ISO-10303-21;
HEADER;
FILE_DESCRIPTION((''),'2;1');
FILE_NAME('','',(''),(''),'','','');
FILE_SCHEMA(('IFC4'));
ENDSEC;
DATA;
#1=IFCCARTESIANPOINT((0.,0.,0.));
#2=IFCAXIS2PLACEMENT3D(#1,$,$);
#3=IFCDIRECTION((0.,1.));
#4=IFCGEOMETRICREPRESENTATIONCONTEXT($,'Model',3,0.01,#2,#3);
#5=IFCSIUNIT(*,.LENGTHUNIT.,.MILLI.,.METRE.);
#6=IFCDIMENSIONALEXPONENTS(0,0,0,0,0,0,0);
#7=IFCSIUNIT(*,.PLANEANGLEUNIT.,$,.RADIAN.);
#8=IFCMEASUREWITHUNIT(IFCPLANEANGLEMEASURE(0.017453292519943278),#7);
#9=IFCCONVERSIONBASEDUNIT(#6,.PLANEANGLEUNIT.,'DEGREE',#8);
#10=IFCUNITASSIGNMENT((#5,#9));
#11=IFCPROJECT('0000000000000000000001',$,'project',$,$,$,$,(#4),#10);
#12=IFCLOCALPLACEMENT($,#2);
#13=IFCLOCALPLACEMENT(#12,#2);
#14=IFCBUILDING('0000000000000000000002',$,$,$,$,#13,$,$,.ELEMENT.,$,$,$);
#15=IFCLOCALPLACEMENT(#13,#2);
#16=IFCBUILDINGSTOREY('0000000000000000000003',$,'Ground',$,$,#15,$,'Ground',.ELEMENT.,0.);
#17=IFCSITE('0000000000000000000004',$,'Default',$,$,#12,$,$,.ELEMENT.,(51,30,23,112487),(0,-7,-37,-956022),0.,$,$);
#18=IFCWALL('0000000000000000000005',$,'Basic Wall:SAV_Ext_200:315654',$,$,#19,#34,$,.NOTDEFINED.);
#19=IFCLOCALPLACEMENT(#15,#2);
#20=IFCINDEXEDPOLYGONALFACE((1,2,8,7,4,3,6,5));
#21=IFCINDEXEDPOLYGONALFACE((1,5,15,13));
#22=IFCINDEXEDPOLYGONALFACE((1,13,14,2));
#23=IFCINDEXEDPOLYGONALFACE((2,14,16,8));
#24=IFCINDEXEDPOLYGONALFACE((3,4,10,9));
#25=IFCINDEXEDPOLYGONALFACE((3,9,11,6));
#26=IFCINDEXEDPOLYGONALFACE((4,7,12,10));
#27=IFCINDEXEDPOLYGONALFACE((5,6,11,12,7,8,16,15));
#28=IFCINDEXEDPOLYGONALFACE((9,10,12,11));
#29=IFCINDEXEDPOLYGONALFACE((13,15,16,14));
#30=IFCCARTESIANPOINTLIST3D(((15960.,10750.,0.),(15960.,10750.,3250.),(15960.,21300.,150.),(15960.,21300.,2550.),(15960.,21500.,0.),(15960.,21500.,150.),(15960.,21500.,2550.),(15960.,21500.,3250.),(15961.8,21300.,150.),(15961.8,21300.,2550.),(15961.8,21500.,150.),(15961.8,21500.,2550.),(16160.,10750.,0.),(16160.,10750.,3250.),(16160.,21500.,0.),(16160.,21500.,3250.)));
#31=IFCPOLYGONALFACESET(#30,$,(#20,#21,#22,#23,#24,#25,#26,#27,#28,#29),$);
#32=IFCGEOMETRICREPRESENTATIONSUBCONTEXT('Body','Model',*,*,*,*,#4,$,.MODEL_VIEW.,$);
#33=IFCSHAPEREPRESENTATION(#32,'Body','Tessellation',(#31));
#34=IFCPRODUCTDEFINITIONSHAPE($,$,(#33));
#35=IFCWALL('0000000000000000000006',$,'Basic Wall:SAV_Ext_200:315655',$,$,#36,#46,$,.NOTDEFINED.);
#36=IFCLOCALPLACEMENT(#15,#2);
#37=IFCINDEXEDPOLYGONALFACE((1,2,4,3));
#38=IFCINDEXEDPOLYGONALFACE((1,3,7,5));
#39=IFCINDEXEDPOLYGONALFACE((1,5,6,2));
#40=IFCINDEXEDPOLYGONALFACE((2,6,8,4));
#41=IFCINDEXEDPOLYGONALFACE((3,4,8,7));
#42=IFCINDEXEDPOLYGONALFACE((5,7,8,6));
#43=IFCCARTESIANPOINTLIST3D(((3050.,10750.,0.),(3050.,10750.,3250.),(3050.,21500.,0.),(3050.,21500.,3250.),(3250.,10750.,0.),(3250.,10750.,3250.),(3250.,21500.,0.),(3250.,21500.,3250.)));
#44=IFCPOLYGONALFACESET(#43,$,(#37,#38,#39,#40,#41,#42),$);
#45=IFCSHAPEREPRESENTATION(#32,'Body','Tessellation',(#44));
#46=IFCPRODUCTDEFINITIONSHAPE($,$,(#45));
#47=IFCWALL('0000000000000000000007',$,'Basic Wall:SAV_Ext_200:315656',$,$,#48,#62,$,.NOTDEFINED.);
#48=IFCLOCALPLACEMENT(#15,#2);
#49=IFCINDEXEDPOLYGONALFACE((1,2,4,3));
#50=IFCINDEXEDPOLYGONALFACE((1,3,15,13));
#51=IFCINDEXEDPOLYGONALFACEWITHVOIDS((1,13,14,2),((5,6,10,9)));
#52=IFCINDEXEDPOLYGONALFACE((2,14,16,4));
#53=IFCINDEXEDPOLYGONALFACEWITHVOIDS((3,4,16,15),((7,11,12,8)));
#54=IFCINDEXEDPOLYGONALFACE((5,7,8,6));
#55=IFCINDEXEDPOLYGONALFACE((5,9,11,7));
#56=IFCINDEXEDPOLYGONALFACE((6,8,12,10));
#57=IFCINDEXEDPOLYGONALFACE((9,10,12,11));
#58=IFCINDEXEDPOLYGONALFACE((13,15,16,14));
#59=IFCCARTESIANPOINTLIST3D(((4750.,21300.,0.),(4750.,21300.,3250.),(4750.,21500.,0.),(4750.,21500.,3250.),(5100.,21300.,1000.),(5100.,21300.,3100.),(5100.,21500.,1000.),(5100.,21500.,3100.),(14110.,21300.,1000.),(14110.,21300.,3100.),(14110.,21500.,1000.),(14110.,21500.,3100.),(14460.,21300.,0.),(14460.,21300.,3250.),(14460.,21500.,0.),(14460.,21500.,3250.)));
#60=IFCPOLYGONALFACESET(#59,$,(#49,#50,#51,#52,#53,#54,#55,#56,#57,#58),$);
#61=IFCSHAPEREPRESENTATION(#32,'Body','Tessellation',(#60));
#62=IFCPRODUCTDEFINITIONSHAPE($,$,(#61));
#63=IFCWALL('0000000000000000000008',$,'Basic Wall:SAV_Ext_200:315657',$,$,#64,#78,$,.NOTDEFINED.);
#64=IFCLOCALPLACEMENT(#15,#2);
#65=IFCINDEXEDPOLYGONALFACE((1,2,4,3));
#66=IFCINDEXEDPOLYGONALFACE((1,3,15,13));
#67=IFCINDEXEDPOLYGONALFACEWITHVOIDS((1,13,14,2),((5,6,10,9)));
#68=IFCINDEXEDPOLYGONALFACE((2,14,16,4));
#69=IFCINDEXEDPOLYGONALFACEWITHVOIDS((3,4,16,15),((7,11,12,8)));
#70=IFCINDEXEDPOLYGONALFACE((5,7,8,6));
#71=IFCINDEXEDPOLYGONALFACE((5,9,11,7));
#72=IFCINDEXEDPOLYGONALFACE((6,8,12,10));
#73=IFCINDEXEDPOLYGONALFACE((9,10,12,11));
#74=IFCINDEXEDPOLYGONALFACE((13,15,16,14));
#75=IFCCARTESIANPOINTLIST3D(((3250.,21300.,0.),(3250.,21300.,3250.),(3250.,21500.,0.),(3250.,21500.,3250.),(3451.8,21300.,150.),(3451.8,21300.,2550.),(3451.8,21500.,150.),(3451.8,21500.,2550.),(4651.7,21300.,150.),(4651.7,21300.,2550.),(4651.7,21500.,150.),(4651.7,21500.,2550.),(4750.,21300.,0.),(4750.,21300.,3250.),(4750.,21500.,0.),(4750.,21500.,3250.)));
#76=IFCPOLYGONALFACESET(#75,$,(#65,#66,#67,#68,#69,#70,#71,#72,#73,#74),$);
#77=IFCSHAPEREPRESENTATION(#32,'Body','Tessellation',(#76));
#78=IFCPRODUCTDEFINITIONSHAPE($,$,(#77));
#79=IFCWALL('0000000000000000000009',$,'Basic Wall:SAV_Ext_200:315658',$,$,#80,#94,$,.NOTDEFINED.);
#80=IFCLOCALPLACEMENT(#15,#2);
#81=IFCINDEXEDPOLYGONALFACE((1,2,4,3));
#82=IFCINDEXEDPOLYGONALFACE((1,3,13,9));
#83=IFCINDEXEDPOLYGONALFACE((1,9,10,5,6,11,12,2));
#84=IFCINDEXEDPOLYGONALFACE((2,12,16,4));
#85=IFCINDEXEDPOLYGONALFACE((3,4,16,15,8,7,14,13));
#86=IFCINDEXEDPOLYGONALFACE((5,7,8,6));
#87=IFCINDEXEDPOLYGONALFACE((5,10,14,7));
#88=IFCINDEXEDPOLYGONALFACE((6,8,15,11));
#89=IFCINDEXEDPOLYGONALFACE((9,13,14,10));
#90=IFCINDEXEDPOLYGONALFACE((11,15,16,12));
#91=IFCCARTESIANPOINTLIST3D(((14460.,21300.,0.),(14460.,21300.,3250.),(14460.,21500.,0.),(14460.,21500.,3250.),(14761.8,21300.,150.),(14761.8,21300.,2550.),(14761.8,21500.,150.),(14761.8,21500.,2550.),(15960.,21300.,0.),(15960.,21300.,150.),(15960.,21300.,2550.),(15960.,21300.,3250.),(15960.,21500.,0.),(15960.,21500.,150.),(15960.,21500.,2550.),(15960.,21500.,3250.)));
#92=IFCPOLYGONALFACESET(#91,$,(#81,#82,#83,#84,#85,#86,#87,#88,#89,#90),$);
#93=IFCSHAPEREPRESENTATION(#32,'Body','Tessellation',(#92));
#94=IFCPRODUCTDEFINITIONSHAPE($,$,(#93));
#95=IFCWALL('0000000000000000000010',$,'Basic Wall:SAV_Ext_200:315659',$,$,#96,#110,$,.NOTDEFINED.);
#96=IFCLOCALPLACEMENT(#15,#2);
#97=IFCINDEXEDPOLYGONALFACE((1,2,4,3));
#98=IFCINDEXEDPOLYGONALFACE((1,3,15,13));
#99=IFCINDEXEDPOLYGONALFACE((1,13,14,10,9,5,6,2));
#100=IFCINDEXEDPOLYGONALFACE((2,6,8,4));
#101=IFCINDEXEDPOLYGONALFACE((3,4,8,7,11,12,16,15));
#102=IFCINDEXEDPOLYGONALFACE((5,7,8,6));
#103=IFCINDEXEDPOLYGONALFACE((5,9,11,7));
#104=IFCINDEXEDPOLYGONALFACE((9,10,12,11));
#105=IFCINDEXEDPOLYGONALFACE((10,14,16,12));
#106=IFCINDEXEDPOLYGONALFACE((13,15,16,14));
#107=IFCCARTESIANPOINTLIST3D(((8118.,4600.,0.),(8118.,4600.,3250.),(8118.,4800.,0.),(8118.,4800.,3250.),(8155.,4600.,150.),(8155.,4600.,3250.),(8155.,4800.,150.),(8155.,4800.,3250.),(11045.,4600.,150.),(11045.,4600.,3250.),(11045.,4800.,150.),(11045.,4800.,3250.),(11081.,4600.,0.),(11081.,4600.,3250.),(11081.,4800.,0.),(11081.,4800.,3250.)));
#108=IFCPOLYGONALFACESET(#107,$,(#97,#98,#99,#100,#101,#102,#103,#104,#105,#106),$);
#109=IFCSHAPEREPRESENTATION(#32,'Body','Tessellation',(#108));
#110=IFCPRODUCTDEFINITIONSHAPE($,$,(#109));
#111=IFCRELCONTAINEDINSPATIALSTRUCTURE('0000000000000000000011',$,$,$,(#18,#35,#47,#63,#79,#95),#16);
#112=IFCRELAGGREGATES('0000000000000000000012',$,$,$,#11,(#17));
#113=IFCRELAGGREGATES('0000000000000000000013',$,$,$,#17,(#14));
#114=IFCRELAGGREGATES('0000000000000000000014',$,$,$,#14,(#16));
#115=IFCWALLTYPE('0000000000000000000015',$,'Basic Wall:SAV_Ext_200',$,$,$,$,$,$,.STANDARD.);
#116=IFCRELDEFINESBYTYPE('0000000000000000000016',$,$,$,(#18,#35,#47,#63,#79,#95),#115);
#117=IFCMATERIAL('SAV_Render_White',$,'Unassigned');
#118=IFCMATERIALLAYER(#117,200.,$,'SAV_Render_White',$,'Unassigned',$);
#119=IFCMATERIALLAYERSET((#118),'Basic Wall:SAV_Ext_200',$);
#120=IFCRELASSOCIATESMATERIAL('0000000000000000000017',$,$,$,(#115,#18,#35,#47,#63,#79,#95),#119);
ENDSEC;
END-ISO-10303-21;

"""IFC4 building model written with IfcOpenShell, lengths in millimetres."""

from ifc_helpers import new_model, entity, si_unit, converted_unit, direction, frame, frame_2d, origin, place, context, subcontext, project, spatial, rectangle, extrude, material, layer, layer_set, layer_usage, type_object, element, save


model = new_model("IFC4")

# Units and contexts
model_context = context("Model", 3, precision=0.01, world=origin(), true_north=direction((0.0, 1.0)))
body_context = subcontext(model_context, "Body", "Model", "MODEL_VIEW")
ifc_project = project(units=[si_unit("LENGTHUNIT", "METRE", prefix="MILLI"), converted_unit("PLANEANGLEUNIT", "DEGREE", entity("IfcPlaneAngleMeasure", 0.017453292519943278), si_unit("PLANEANGLEUNIT", "RADIAN"), dimensions=[0, 0, 0, 0, 0, 0, 0])], contexts=[model_context])

# Site, building, storey
site_placement = place(None, origin())
site = spatial("IfcSite", under=ifc_project, at=site_placement, Name="Default", CompositionType="ELEMENT", RefLatitude=(51, 30, 23, 112487), RefLongitude=(0, -7, -37, -956022), RefElevation=0.0)
building_placement = place(site_placement, origin())
building = spatial("IfcBuilding", under=site, at=building_placement, CompositionType="ELEMENT")
storey_placement = place(building_placement, origin())
storey = spatial("IfcBuildingStorey", under=building, at=storey_placement, Name="Ground", LongName="Ground", CompositionType="ELEMENT", Elevation=0.0)

# Shared definitions
ifc_material = material(Name="SAV_Render_White", Category="Unassigned")
ifc_layer = layer(ifc_material, 200.0, Name="SAV_Render_White", Category="Unassigned")
ifc_layer_set = layer_set([ifc_layer], Name="Basic Wall:SAV_Ext_200")
wall_type = type_object("IfcWallType", Name="Basic Wall:SAV_Ext_200", PredefinedType="STANDARD", material=ifc_layer_set)

# Wall, opening
ifc_layer_usage_1 = layer_usage(ifc_layer_set, "AXIS2", "NEGATIVE", 100.0)
wall_1_placement = place(storey_placement, frame((16060.0, 10750.0, 0.0), z_axis=(0.0, 0.0, 1.0), x_axis=(0.0, 1.0, 0.0)))
wall_1 = element("IfcWall", 1, at=wall_1_placement, inside=storey, type_object=wall_type, material=ifc_layer_usage_1, Name="Basic Wall:SAV_Ext_200:315654", PredefinedType="NOTDEFINED", context=body_context, shape_type="SweptSolid", body=[
    extrude(rectangle(XDim=10750.0, YDim=200.0, at=frame_2d((5375.0, 0.0), x_axis=(-1.0, 0.0))), origin(), (0.0, 0.0, 1.0), 3250.0),
])
opening_1_placement = place(wall_1_placement, frame((-10750.0, 16060.0, 150.0)))
element("IfcOpeningElement", 2, at=opening_1_placement, cuts=wall_1, PredefinedType="OPENING", context=body_context, shape_type="SweptSolid", body=[
    extrude(rectangle(XDim=2400.0, YDim=200.0, at=frame_2d((0.0, 0.0), x_axis=(0.0, 1.0))), frame((21400.0, -15961.8, 1200.0), z_axis=(0.0, 1.0, 0.0), x_axis=(1.0, 0.0, 0.0)), (0.0, 0.0, 1.0), 1200.0),
])

# Wall
ifc_layer_usage_2 = layer_usage(ifc_layer_set, "AXIS2", "NEGATIVE", 100.0)
wall_2_placement = place(storey_placement, frame((3150.0, 21500.0, 0.0), z_axis=(0.0, 0.0, 1.0), x_axis=(0.0, -1.0, 0.0)))
element("IfcWall", 3, at=wall_2_placement, inside=storey, type_object=wall_type, material=ifc_layer_usage_2, Name="Basic Wall:SAV_Ext_200:315655", PredefinedType="NOTDEFINED", context=body_context, shape_type="SweptSolid", body=[
    extrude(rectangle(XDim=10750.0, YDim=200.0, at=frame_2d((5375.0, 0.0), x_axis=(-1.0, 0.0))), origin(), (0.0, 0.0, 1.0), 3250.0),
])

# Walls, openings
ifc_layer_usage_3 = layer_usage(ifc_layer_set, "AXIS2", "NEGATIVE", 100.0)
wall_3_placement = place(storey_placement, frame((4750.0, 21400.0, 0.0)))
wall_3 = element("IfcWall", 4, at=wall_3_placement, inside=storey, type_object=wall_type, material=ifc_layer_usage_3, Name="Basic Wall:SAV_Ext_200:315656", PredefinedType="NOTDEFINED", context=body_context, shape_type="SweptSolid", body=[
    extrude(rectangle(XDim=9710.0, YDim=200.0, at=frame_2d((4855.0, 0.0), x_axis=(-1.0, 0.0))), origin(), (0.0, 0.0, 1.0), 3250.0),
])
opening_2_placement = place(wall_3_placement, frame((350.0, -100.0, 1000.0)))
element("IfcOpeningElement", 5, at=opening_2_placement, cuts=wall_3, PredefinedType="OPENING", context=body_context, shape_type="SweptSolid", body=[
    extrude(rectangle(XDim=2100.0, YDim=9010.0, at=frame_2d((1050.0, 4505.0), x_axis=(-1.0, 0.0))), frame((0.0, 0.0, 0.0), z_axis=(0.0, 1.0, 0.0), x_axis=(0.0, 0.0, 1.0)), (0.0, 0.0, 1.0), 200.0),
])
ifc_layer_usage_4 = layer_usage(ifc_layer_set, "AXIS2", "NEGATIVE", 100.0)
wall_4_placement = place(storey_placement, frame((3250.0, 21400.0, 0.0)))
wall_4 = element("IfcWall", 6, at=wall_4_placement, inside=storey, type_object=wall_type, material=ifc_layer_usage_4, Name="Basic Wall:SAV_Ext_200:315657", PredefinedType="NOTDEFINED", context=body_context, shape_type="SweptSolid", body=[
    extrude(rectangle(XDim=1500.0, YDim=200.0, at=frame_2d((750.0, 0.0), x_axis=(-1.0, 0.0))), origin(), (0.0, 0.0, 1.0), 3250.0),
])
opening_3_placement = place(wall_4_placement, frame((1401.7, 100.0, 150.0)))
element("IfcOpeningElement", 7, at=opening_3_placement, cuts=wall_4, PredefinedType="OPENING", context=body_context, shape_type="SweptSolid", body=[
    extrude(rectangle(XDim=2400.0, YDim=1200.0, at=frame_2d((1200.0, 600.0), x_axis=(-1.0, 0.0))), frame((0.0, 0.0, 0.0), z_axis=(0.0, -1.0, 0.0), x_axis=(0.0, 0.0, 1.0)), (0.0, 0.0, 1.0), 200.0),
])
ifc_layer_usage_5 = layer_usage(ifc_layer_set, "AXIS2", "NEGATIVE", 100.0)
wall_5_placement = place(storey_placement, frame((14460.0, 21400.0, 0.0)))
wall_5 = element("IfcWall", 8, at=wall_5_placement, inside=storey, type_object=wall_type, material=ifc_layer_usage_5, Name="Basic Wall:SAV_Ext_200:315658", PredefinedType="NOTDEFINED", context=body_context, shape_type="SweptSolid", body=[
    extrude(rectangle(XDim=1500.0, YDim=200.0, at=frame_2d((750.0, 0.0), x_axis=(-1.0, 0.0))), origin(), (0.0, 0.0, 1.0), 3250.0),
])
opening_4_placement = place(wall_5_placement, frame((1501.7, 100.0, 150.0)))
element("IfcOpeningElement", 9, at=opening_4_placement, cuts=wall_5, PredefinedType="OPENING", context=body_context, shape_type="SweptSolid", body=[
    extrude(rectangle(XDim=2400.0, YDim=1200.0, at=frame_2d((1200.0, 600.0), x_axis=(-1.0, 0.0))), frame((0.0, 0.0, 0.0), z_axis=(0.0, -1.0, 0.0), x_axis=(0.0, 0.0, 1.0)), (0.0, 0.0, 1.0), 200.0),
])
ifc_layer_usage_6 = layer_usage(ifc_layer_set, "AXIS2", "NEGATIVE", 100.0)
wall_6_placement = place(storey_placement, frame((8118.0, 4700.0, 0.0)))
wall_6 = element("IfcWall", 10, at=wall_6_placement, inside=storey, type_object=wall_type, material=ifc_layer_usage_6, Name="Basic Wall:SAV_Ext_200:315659", PredefinedType="NOTDEFINED", context=body_context, shape_type="SweptSolid", body=[
    extrude(rectangle(XDim=2963.0, YDim=200.0, at=frame_2d((1481.5, 0.0), x_axis=(-1.0, 0.0))), origin(), (0.0, 0.0, 1.0), 3250.0),
])
opening_5_placement = place(wall_6_placement, frame((2927.0, 100.0, 150.0)))
element("IfcOpeningElement", 11, at=opening_5_placement, cuts=wall_6, PredefinedType="OPENING", context=body_context, shape_type="SweptSolid", body=[
    extrude(rectangle(XDim=3100.0, YDim=2890.0, at=frame_2d((1550.0, 1445.0), x_axis=(-1.0, 0.0))), frame((0.0, 0.0, 0.0), z_axis=(0.0, -1.0, 0.0), x_axis=(0.0, 0.0, 1.0)), (0.0, 0.0, 1.0), 200.0),
])

save(model, "model.ifc")
